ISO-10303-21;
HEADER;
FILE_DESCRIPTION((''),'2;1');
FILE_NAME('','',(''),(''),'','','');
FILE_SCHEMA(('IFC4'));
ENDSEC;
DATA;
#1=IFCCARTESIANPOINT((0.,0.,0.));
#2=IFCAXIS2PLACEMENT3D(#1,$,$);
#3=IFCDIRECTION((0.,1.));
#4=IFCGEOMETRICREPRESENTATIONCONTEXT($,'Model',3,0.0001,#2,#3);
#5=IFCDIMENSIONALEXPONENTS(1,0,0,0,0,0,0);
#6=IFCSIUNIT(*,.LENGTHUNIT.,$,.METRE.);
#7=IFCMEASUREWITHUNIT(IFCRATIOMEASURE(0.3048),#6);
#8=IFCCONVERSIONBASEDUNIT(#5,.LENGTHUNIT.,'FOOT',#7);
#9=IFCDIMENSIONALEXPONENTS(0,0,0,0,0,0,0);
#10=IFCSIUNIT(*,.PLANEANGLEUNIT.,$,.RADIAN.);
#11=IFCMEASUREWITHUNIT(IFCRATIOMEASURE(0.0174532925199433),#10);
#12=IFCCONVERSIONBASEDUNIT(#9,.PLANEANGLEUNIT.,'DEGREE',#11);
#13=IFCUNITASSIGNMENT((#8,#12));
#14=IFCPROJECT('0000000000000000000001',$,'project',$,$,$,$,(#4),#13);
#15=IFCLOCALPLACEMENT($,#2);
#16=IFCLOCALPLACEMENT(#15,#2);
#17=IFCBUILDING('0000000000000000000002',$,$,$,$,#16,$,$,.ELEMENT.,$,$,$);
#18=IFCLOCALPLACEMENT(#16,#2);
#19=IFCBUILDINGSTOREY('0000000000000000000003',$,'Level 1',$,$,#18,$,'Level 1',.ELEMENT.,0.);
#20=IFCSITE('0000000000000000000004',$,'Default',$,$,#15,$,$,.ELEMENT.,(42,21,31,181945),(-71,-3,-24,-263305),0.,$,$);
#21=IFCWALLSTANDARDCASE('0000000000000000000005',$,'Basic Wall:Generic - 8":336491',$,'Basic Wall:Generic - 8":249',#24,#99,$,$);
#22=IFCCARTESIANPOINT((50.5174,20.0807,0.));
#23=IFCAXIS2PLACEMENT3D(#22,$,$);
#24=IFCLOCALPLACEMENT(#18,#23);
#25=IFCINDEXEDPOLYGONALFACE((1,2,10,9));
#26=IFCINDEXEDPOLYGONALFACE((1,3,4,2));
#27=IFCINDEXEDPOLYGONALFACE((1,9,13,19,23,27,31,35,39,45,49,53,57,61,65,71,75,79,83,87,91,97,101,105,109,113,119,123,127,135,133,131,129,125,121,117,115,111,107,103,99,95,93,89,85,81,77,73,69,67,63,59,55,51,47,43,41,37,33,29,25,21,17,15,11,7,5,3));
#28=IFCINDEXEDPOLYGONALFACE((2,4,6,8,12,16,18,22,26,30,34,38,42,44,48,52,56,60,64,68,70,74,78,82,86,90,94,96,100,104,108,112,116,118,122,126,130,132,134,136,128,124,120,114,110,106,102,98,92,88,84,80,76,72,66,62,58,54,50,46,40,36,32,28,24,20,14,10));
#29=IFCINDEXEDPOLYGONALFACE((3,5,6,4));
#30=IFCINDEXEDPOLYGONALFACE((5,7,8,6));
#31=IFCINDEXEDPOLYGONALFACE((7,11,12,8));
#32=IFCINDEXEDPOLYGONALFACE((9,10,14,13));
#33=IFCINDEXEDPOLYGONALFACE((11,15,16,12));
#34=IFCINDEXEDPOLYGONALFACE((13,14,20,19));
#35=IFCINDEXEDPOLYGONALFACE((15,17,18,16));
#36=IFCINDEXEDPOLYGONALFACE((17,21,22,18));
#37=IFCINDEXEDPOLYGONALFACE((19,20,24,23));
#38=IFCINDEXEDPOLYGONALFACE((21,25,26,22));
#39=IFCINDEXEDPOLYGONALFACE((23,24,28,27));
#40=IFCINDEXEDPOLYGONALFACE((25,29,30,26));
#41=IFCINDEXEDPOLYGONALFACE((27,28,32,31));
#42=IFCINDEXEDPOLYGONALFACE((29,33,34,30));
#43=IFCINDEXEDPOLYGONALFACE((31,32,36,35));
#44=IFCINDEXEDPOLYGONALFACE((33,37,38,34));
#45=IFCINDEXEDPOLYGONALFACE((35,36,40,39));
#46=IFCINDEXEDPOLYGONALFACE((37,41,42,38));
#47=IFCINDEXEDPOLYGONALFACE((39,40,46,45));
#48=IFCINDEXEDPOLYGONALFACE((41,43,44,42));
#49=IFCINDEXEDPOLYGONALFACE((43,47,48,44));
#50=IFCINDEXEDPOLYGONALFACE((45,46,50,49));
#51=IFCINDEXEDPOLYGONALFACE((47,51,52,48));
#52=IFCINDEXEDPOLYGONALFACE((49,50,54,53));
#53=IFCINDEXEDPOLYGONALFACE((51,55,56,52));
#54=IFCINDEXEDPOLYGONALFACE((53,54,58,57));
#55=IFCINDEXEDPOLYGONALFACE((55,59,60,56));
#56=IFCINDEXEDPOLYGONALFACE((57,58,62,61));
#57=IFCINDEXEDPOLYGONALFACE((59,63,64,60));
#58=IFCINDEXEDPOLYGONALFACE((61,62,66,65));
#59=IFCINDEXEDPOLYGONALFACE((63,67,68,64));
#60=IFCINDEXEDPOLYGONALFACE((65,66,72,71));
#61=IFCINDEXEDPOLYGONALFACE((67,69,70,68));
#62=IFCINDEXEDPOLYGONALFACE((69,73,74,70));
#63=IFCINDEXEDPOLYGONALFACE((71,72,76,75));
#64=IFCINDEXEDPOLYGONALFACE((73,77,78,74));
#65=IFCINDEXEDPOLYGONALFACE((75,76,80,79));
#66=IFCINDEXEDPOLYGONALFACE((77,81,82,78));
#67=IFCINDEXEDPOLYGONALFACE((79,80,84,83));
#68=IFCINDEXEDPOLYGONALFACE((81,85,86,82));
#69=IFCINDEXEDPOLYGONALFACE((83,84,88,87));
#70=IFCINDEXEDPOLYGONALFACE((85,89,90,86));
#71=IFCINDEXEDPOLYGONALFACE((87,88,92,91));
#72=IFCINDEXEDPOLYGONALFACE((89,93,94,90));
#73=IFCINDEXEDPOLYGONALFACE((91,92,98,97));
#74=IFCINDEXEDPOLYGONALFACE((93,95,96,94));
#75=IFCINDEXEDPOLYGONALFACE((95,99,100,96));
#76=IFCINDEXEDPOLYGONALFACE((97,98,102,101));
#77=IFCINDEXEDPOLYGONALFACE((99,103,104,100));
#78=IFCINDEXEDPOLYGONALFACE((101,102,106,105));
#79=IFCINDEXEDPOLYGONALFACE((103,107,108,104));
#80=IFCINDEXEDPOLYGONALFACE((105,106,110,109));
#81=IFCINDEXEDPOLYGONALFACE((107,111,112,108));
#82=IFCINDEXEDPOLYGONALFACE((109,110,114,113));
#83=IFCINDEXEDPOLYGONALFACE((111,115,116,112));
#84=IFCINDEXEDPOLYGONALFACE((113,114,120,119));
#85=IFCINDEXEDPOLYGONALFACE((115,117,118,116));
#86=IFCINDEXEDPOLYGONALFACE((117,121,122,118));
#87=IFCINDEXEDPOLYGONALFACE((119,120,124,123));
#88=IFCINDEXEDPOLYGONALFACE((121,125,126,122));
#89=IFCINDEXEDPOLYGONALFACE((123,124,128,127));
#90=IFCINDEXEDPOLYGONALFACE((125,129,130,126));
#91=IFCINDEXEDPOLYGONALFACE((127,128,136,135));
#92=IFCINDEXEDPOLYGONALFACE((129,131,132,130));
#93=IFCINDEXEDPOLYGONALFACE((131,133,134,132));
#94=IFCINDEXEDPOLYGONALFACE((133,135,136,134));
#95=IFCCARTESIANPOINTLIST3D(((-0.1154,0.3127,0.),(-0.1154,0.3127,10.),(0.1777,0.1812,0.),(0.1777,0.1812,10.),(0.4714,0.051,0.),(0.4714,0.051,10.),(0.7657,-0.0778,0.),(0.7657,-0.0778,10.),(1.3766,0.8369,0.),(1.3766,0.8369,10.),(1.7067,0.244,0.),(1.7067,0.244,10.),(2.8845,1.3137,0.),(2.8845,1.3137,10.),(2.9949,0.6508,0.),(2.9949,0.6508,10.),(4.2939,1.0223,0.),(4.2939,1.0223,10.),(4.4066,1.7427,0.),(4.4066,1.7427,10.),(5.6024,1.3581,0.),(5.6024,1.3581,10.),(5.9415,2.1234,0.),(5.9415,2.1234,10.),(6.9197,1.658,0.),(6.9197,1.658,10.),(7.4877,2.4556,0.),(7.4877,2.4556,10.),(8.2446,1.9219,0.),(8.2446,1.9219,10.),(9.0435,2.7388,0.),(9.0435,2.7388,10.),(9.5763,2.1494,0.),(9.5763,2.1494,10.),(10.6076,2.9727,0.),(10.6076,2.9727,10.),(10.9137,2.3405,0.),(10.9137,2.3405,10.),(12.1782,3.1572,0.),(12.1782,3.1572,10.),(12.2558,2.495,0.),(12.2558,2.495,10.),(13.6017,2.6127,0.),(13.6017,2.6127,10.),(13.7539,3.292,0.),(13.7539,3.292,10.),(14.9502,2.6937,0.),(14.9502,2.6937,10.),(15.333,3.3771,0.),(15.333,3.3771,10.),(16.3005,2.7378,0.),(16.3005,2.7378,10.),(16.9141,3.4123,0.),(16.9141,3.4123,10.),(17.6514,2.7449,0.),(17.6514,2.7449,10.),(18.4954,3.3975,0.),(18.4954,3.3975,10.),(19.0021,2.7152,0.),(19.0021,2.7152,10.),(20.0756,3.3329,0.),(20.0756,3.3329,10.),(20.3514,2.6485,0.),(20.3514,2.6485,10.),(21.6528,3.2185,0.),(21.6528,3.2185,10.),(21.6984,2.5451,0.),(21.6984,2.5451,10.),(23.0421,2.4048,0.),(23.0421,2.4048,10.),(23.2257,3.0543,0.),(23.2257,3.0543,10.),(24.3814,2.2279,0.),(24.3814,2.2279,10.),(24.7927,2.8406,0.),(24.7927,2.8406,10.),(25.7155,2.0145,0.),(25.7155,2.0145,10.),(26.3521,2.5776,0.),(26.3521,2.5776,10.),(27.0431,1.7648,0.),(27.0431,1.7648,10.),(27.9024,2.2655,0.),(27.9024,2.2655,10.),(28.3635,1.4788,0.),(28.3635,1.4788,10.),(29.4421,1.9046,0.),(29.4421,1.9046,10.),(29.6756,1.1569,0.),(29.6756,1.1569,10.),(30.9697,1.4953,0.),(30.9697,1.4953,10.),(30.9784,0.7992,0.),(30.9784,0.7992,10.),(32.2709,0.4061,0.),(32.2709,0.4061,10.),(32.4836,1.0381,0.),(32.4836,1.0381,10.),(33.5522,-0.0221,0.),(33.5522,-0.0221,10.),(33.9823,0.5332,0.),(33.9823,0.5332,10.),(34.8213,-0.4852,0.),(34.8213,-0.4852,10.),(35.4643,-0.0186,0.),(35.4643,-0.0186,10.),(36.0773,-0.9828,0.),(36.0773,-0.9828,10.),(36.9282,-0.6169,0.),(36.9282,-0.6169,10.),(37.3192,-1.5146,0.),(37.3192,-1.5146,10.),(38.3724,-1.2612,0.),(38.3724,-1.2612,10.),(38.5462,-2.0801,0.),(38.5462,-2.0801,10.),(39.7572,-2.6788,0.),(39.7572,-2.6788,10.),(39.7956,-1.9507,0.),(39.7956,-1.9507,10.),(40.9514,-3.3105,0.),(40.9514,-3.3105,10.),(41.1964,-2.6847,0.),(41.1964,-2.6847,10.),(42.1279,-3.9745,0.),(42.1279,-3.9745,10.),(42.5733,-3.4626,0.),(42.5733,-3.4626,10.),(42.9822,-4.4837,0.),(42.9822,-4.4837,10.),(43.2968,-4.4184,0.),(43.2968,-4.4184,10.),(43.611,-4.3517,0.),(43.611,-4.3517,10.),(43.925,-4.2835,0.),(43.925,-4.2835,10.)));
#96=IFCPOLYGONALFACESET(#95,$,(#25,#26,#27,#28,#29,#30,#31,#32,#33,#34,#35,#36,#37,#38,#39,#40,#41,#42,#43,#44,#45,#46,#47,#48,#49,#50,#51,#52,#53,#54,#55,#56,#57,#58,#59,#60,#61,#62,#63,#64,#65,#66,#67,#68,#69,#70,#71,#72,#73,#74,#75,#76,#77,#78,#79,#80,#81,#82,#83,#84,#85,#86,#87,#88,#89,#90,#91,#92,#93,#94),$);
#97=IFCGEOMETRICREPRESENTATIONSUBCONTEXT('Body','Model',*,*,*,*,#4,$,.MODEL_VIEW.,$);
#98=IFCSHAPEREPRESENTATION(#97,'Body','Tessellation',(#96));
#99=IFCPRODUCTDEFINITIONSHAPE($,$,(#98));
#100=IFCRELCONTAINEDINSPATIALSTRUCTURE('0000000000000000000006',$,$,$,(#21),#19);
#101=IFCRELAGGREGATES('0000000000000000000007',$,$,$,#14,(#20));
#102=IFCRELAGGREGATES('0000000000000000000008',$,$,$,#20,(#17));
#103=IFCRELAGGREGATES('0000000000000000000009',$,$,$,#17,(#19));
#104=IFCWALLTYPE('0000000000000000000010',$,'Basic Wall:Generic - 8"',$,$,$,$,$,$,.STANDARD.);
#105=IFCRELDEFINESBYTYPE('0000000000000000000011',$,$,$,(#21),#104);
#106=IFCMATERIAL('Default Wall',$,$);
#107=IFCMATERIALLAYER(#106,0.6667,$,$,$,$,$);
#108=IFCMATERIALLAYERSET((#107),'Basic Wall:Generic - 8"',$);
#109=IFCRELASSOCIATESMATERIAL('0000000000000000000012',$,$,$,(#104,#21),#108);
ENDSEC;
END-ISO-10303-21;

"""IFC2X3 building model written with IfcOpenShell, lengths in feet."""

from ifc_helpers import new_model, entity, si_unit, converted_unit, direction, frame, frame_2d, origin, place, context, subcontext, project, spatial, polyline, circle_curve, parameter, trimmed, segment, composite_curve, outline, extrude, material, layer, layer_set, layer_usage, type_object, element, save


model = new_model("IFC2X3")

# Units and contexts
model_context = context("Model", 3, precision=0.0001, world=origin(), true_north=direction((0.0, 1.0)))
body_context = subcontext(model_context, "Body", "Model", "MODEL_VIEW")
ifc_project = project(units=[converted_unit("LENGTHUNIT", "FOOT", entity("IfcRatioMeasure", 0.3048), si_unit("LENGTHUNIT", "METRE"), dimensions=[1, 0, 0, 0, 0, 0, 0]), converted_unit("PLANEANGLEUNIT", "DEGREE", entity("IfcRatioMeasure", 0.0174532925199433), si_unit("PLANEANGLEUNIT", "RADIAN"), dimensions=[0, 0, 0, 0, 0, 0, 0])], contexts=[model_context])

# Site, building, storey
site_placement = place(None, origin())
site = spatial("IfcSite", under=ifc_project, at=site_placement, Name="Default", CompositionType="ELEMENT", RefLatitude=(42, 21, 31, 181945), RefLongitude=(-71, -3, -24, -263305), RefElevation=0.0)
building_placement = place(site_placement, origin())
building = spatial("IfcBuilding", under=site, at=building_placement, CompositionType="ELEMENT")
storey_placement = place(building_placement, origin())
storey = spatial("IfcBuildingStorey", under=building, at=storey_placement, Name="Level 1", LongName="Level 1", CompositionType="ELEMENT", Elevation=0.0)

# Shared definitions
ifc_material_1 = material(Name="Default Wall")
ifc_layer = layer(ifc_material_1, 0.6667)
ifc_layer_set = layer_set([ifc_layer], Name="Basic Wall:Generic - 8\"")
wall_type = type_object("IfcWallType", Name="Basic Wall:Generic - 8\"", PredefinedType="STANDARD", material=ifc_layer_set)

# Wall
ifc_layer_usage_1 = layer_usage(ifc_layer_set, "AXIS2", "POSITIVE", -0.3333)
wall_1_placement = place(storey_placement, frame((50.5174, 20.0807, 0.0)))
element("IfcWallStandardCase", 1, at=wall_1_placement, inside=storey, type_object=wall_type, material=ifc_layer_usage_1, Name="Basic Wall:Generic - 8\":336491", ObjectType="Basic Wall:Generic - 8\":249", context=body_context, shape_type="SweptSolid", body=[
    extrude(outline(composite_curve([segment(trimmed(circle_curve(frame_2d((17.2382, -46.6998), x_axis=(1.0, 0.0)), 50.1132), [parameter(57.823435)], [parameter(110.260481)], True, "PARAMETER"), True, "CONTINUOUS"), segment(trimmed(circle_curve(frame_2d((28.8377, 64.4446), x_axis=(1.0, 0.0)), 70.3646), [parameter(245.702645)], [parameter(246.487431)], True, "PARAMETER"), True, "CONTINUOUS"), segment(polyline([(0.7657, -0.0778), (1.7067, 0.244)]), True, "CONTINUOUS"), segment(polyline([(1.7067, 0.244), (2.9949, 0.6508)]), True, "CONTINUOUS"), segment(polyline([(2.9949, 0.6508), (4.2939, 1.0223)]), True, "CONTINUOUS"), segment(polyline([(4.2939, 1.0223), (5.6024, 1.3581)]), True, "CONTINUOUS"), segment(polyline([(5.6024, 1.3581), (6.9197, 1.658)]), True, "CONTINUOUS"), segment(polyline([(6.9197, 1.658), (8.2446, 1.9219)]), True, "CONTINUOUS"), segment(polyline([(8.2446, 1.9219), (9.5763, 2.1494)]), True, "CONTINUOUS"), segment(polyline([(9.5763, 2.1494), (10.9137, 2.3405)]), True, "CONTINUOUS"), segment(polyline([(10.9137, 2.3405), (12.2558, 2.495)]), True, "CONTINUOUS"), segment(polyline([(12.2558, 2.495), (13.6017, 2.6127)]), True, "CONTINUOUS"), segment(polyline([(13.6017, 2.6127), (14.9502, 2.6937)]), True, "CONTINUOUS"), segment(polyline([(14.9502, 2.6937), (16.3005, 2.7378)]), True, "CONTINUOUS"), segment(polyline([(16.3005, 2.7378), (17.6514, 2.7449)]), True, "CONTINUOUS"), segment(polyline([(17.6514, 2.7449), (19.0021, 2.7152)]), True, "CONTINUOUS"), segment(polyline([(19.0021, 2.7152), (20.3514, 2.6485)]), True, "CONTINUOUS"), segment(polyline([(20.3514, 2.6485), (21.6984, 2.5451)]), True, "CONTINUOUS"), segment(polyline([(21.6984, 2.5451), (23.0421, 2.4048)]), True, "CONTINUOUS"), segment(polyline([(23.0421, 2.4048), (24.3814, 2.2279)]), True, "CONTINUOUS"), segment(polyline([(24.3814, 2.2279), (25.7155, 2.0145)]), True, "CONTINUOUS"), segment(polyline([(25.7155, 2.0145), (27.0431, 1.7648)]), True, "CONTINUOUS"), segment(polyline([(27.0431, 1.7648), (28.3635, 1.4788)]), True, "CONTINUOUS"), segment(polyline([(28.3635, 1.4788), (29.6756, 1.1569)]), True, "CONTINUOUS"), segment(polyline([(29.6756, 1.1569), (30.9784, 0.7992)]), True, "CONTINUOUS"), segment(polyline([(30.9784, 0.7992), (32.2709, 0.4061)]), True, "CONTINUOUS"), segment(polyline([(32.2709, 0.4061), (33.5522, -0.0221)]), True, "CONTINUOUS"), segment(polyline([(33.5522, -0.0221), (34.8213, -0.4852)]), True, "CONTINUOUS"), segment(polyline([(34.8213, -0.4852), (36.0773, -0.9828)]), True, "CONTINUOUS"), segment(polyline([(36.0773, -0.9828), (37.3192, -1.5146)]), True, "CONTINUOUS"), segment(polyline([(37.3192, -1.5146), (38.5462, -2.0801)]), True, "CONTINUOUS"), segment(polyline([(38.5462, -2.0801), (39.7572, -2.6788)]), True, "CONTINUOUS"), segment(polyline([(39.7572, -2.6788), (40.9514, -3.3105)]), True, "CONTINUOUS"), segment(polyline([(40.9514, -3.3105), (42.1279, -3.9745)]), True, "CONTINUOUS"), segment(polyline([(42.1279, -3.9745), (42.9822, -4.4837)]), True, "CONTINUOUS"), segment(trimmed(circle_curve(frame_2d((28.8377, 64.4446), x_axis=(1.0, 0.0)), 70.3646), [parameter(281.596484)], [parameter(282.381271)], True, "PARAMETER"), True, "CONTINUOUS")], self_intersect=False)), origin(), (0.0, 0.0, 1.0), 10.0),
])

save(model, "model.ifc")
